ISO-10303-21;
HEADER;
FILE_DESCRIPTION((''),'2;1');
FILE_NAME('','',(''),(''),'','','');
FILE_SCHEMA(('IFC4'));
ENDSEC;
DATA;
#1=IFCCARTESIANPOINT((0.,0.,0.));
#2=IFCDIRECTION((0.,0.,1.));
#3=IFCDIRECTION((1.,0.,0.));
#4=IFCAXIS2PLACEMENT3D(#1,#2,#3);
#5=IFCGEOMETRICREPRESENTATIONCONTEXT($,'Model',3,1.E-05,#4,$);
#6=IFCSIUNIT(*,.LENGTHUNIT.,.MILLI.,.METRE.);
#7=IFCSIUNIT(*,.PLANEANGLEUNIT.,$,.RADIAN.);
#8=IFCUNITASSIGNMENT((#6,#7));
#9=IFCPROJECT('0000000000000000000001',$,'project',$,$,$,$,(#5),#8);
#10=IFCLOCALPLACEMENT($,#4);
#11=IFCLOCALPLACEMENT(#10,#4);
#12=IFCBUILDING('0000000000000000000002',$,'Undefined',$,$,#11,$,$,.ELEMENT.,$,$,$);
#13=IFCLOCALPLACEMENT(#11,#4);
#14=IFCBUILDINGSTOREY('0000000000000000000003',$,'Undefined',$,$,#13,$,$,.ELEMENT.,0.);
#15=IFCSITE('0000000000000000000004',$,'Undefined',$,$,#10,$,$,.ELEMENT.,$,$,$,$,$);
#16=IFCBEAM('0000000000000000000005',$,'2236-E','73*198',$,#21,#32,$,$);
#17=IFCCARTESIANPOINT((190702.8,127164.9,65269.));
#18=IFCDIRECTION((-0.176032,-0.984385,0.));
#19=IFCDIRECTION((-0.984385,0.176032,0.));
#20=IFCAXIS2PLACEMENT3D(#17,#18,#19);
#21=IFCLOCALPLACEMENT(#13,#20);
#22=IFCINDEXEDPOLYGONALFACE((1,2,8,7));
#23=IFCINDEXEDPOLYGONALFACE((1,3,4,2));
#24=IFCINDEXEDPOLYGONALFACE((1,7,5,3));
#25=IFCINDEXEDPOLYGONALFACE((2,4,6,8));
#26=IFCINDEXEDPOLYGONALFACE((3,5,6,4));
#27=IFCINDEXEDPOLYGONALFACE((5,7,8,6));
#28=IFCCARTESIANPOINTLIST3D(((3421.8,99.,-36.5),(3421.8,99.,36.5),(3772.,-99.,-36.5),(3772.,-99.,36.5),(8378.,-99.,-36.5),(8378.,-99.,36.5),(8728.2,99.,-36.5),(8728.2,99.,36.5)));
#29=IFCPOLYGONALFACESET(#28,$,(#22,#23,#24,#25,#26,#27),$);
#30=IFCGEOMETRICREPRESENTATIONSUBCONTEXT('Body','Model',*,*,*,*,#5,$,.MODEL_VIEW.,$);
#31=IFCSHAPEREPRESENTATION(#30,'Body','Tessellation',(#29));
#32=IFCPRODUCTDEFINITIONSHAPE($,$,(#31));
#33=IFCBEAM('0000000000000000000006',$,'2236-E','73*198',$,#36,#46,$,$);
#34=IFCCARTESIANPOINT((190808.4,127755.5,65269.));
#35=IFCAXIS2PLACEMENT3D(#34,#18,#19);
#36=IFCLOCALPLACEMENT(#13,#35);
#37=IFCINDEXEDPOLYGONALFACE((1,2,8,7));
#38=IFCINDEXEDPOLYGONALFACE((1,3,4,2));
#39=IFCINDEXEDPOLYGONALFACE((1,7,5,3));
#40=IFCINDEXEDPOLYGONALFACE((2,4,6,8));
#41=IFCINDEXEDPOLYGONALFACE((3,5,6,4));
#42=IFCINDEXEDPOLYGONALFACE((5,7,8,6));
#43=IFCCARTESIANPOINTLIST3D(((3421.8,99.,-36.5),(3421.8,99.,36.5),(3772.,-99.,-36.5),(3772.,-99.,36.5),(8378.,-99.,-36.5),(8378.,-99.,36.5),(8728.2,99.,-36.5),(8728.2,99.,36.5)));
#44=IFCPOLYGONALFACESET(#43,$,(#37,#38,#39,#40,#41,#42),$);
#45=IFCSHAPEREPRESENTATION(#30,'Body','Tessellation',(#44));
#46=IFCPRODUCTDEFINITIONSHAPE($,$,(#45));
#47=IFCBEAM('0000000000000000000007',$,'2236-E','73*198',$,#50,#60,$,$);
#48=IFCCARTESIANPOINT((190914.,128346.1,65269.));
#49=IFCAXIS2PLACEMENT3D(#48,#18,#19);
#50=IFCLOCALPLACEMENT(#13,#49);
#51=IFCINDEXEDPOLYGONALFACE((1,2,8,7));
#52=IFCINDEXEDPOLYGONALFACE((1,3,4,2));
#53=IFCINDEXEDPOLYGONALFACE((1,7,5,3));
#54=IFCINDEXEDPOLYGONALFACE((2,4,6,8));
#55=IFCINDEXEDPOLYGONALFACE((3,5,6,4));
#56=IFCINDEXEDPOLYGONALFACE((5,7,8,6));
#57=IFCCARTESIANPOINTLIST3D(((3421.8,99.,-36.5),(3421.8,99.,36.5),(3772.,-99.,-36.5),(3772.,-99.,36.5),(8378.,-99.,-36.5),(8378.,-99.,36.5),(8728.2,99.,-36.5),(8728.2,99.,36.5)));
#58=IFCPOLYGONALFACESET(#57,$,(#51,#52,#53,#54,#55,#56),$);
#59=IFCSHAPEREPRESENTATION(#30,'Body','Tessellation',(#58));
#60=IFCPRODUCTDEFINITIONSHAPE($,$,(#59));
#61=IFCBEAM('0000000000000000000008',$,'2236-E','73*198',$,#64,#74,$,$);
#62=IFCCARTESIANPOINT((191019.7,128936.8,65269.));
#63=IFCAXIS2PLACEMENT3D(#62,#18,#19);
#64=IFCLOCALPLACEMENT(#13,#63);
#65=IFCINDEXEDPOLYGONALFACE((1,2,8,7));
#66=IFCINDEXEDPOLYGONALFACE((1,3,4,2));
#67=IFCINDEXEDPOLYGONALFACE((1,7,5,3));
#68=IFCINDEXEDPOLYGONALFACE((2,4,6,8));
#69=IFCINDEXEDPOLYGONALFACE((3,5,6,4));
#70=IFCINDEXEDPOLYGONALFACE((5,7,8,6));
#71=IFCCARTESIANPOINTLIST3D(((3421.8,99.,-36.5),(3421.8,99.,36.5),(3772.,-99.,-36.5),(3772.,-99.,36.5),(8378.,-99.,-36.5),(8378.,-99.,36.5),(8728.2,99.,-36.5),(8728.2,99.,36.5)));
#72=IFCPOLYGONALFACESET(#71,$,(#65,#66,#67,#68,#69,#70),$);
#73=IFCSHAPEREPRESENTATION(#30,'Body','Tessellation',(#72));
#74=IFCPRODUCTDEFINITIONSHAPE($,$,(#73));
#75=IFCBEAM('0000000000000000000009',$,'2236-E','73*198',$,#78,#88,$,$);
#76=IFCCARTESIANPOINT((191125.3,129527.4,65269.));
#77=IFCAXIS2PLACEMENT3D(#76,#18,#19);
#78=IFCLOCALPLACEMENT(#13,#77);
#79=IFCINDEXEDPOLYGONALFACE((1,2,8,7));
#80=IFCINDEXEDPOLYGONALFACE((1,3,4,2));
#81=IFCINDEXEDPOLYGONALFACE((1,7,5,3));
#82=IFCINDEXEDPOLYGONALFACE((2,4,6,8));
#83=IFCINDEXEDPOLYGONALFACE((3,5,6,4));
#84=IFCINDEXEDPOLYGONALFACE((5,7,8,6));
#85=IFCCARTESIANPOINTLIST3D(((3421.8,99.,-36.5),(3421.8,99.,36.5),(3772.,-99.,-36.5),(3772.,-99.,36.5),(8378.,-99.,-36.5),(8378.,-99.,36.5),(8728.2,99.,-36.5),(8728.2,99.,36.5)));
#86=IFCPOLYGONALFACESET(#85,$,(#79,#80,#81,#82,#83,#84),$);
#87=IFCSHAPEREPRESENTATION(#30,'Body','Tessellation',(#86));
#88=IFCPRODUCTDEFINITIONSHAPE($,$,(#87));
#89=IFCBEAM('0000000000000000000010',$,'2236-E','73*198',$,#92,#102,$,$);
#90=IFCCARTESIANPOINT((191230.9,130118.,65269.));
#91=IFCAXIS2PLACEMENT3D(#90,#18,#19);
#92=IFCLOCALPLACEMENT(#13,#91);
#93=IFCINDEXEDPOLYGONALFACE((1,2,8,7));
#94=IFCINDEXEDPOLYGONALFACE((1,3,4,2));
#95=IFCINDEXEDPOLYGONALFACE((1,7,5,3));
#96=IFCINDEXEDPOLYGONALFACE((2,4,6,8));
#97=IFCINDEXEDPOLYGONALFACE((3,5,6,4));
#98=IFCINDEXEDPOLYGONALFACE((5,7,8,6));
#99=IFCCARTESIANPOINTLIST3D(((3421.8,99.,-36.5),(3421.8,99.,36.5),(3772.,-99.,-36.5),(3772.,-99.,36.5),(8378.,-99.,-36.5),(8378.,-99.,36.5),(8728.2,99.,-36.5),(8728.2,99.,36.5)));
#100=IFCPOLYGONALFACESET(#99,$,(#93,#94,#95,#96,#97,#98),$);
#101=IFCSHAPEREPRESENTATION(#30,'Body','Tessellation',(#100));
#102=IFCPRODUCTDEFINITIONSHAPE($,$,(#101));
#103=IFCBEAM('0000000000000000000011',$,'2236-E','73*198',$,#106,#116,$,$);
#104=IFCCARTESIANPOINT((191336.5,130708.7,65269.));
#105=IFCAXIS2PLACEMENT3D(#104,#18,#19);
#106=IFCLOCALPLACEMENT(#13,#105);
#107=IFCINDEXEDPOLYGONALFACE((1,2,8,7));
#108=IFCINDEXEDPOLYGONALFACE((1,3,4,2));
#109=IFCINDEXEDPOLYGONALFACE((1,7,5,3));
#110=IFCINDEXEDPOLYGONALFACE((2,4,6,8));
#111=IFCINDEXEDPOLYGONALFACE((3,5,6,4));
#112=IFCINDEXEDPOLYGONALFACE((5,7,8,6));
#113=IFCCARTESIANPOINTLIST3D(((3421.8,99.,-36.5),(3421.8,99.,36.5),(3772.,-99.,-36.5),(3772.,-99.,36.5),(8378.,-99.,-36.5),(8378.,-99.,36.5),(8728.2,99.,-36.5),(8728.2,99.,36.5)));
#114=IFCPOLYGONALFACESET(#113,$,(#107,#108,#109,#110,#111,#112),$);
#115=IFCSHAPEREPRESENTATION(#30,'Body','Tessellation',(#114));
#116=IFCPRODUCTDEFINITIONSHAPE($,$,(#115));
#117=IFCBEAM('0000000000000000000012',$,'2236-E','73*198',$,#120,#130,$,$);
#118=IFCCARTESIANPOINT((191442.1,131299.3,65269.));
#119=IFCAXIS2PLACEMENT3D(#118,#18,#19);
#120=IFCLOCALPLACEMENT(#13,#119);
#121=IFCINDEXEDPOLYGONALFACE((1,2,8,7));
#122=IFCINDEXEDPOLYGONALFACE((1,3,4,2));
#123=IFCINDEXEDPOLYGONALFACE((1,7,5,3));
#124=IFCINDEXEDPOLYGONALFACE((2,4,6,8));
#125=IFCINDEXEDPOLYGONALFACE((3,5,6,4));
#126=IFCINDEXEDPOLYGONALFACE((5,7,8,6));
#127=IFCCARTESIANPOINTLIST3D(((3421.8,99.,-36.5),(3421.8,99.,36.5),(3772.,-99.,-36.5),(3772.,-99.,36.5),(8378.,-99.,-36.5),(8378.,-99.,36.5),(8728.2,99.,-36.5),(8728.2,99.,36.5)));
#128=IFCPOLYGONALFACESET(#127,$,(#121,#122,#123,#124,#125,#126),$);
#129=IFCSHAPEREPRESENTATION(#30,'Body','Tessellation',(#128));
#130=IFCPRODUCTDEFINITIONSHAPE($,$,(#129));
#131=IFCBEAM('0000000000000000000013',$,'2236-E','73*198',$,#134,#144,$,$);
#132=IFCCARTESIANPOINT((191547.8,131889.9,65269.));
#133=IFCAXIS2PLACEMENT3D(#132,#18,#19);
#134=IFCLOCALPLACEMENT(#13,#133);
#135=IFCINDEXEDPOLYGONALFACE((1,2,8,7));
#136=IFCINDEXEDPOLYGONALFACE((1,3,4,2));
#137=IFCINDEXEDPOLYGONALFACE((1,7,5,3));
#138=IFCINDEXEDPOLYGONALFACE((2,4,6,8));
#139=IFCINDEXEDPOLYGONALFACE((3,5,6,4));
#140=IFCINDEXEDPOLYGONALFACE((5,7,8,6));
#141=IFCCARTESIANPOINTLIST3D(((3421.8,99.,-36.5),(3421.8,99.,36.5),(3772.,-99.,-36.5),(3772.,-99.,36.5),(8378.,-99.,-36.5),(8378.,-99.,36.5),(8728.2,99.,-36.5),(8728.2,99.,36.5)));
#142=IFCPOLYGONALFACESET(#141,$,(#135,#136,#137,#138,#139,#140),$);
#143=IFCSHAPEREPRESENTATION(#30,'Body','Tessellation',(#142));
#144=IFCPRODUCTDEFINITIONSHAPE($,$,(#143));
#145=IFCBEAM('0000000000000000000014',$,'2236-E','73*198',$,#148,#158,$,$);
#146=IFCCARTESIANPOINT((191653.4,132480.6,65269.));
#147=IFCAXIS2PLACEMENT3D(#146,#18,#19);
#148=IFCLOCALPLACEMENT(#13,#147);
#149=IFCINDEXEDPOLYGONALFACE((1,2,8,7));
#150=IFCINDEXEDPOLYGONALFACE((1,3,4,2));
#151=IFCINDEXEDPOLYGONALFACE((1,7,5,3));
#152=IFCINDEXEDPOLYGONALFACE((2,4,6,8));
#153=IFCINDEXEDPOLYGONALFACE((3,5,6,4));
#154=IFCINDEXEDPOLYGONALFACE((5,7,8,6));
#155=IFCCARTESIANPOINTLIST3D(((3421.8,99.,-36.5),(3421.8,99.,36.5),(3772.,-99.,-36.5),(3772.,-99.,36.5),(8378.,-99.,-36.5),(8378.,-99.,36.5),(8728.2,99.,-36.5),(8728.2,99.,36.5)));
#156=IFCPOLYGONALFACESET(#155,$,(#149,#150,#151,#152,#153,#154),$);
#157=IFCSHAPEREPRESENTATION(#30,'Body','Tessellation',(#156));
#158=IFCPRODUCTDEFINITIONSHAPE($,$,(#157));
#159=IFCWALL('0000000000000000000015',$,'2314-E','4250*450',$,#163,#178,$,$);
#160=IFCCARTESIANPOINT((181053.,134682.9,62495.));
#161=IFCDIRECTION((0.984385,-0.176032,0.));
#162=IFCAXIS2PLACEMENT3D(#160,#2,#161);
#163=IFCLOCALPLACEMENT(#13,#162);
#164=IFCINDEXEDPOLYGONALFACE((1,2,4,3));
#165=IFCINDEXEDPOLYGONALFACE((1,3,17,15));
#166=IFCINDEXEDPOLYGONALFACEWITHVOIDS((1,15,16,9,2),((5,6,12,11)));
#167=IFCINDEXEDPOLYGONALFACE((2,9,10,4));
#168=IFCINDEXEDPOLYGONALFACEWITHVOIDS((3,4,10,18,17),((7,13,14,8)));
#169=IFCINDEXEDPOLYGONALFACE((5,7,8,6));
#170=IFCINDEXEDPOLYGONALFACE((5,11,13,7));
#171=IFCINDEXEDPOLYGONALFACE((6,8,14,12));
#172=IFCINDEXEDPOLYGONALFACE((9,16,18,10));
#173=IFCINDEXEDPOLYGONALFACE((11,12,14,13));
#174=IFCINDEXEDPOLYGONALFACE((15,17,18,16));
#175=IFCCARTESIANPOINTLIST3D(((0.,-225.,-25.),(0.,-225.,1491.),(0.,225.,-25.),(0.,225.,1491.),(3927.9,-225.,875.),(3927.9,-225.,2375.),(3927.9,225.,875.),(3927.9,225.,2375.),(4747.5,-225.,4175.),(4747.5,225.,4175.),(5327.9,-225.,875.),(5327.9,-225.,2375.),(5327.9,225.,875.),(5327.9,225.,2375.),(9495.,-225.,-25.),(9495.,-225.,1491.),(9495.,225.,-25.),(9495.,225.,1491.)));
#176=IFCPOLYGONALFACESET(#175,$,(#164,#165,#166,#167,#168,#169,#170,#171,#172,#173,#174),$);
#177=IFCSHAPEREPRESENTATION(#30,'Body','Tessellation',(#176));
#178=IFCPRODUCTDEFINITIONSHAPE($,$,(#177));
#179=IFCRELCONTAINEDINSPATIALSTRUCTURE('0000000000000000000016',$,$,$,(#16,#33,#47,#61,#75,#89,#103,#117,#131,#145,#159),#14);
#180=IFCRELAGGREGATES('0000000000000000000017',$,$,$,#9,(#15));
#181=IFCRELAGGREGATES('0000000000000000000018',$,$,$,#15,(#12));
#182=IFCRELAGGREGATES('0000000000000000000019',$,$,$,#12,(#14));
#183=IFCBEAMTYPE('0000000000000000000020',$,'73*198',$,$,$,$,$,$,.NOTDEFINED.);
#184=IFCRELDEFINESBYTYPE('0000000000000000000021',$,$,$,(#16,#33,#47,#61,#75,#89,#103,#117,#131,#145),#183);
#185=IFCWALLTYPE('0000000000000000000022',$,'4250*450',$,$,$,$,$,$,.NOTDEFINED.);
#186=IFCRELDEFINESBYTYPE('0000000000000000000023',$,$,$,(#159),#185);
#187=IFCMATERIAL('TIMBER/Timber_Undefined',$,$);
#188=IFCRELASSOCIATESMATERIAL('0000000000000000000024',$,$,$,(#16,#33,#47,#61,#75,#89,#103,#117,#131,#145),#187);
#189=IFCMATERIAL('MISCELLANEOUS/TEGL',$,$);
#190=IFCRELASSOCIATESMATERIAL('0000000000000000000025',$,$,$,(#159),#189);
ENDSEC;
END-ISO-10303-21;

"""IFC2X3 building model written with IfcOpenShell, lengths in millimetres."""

from ifc_helpers import new_model, si_unit, frame, frame_2d, origin_with_axes, origin_2d_with_axis, place, context, subcontext, project, spatial, rectangle, extrude, boolean, clip, halfspace, material, type_object, element, save


model = new_model("IFC2X3")

# Units and contexts
model_context = context("Model", 3, precision=1e-05, world=origin_with_axes())
body_context = subcontext(model_context, "Body", "Model", "MODEL_VIEW")
ifc_project = project(units=[si_unit("LENGTHUNIT", "METRE", prefix="MILLI"), si_unit("PLANEANGLEUNIT", "RADIAN")], contexts=[model_context])

# Site, building, storey
site_placement = place(None, origin_with_axes())
site = spatial("IfcSite", under=ifc_project, at=site_placement, Name="Undefined", CompositionType="ELEMENT")
building_placement = place(site_placement, origin_with_axes())
building = spatial("IfcBuilding", under=site, at=building_placement, Name="Undefined", CompositionType="ELEMENT")
storey_placement = place(building_placement, origin_with_axes())
storey = spatial("IfcBuildingStorey", under=building, at=storey_placement, Name="Undefined", CompositionType="ELEMENT", Elevation=0.0)

# Shared definitions
ifc_material_1 = material(Name="TIMBER/Timber_Undefined")

# Beams
beam_type = type_object("IfcBeamType", Name="73*198", PredefinedType="NOTDEFINED")
for number, where, z_axis, x_axis, name in (
    (1, (190702.8, 127164.9, 65269.0), (-0.176032, -0.984385, 0.0), (-0.984385, 0.176032, 0.0), "2236-E"),
    (2, (190808.4, 127755.5, 65269.0), (-0.176032, -0.984385, 0.0), (-0.984385, 0.176032, 0.0), "2236-E"),
    (3, (190914.0, 128346.1, 65269.0), (-0.176032, -0.984385, 0.0), (-0.984385, 0.176032, 0.0), "2236-E"),
    (4, (191019.7, 128936.8, 65269.0), (-0.176032, -0.984385, 0.0), (-0.984385, 0.176032, 0.0), "2236-E"),
    (5, (191125.3, 129527.4, 65269.0), (-0.176032, -0.984385, 0.0), (-0.984385, 0.176032, 0.0), "2236-E"),
    (6, (191230.9, 130118.0, 65269.0), (-0.176032, -0.984385, 0.0), (-0.984385, 0.176032, 0.0), "2236-E"),
    (7, (191336.5, 130708.7, 65269.0), (-0.176032, -0.984385, 0.0), (-0.984385, 0.176032, 0.0), "2236-E"),
    (8, (191442.1, 131299.3, 65269.0), (-0.176032, -0.984385, 0.0), (-0.984385, 0.176032, 0.0), "2236-E"),
    (9, (191547.8, 131889.9, 65269.0), (-0.176032, -0.984385, 0.0), (-0.984385, 0.176032, 0.0), "2236-E"),
    (10, (191653.4, 132480.6, 65269.0), (-0.176032, -0.984385, 0.0), (-0.984385, 0.176032, 0.0), "2236-E"),
):
    element("IfcBeam", number, at=place(storey_placement, frame(where, z_axis=z_axis, x_axis=x_axis)), inside=storey, type_object=beam_type, material=ifc_material_1, Name=name, Description="73*198", context=body_context, shape_type="Clipping", body=[
        clip(clip(extrude(rectangle(XDim=198.0, YDim=73.0, at=origin_2d_with_axis()), frame((14325.0, 0.0, 0.0), z_axis=(-1.0, 0.0, 0.0), x_axis=(0.0, -1.0, 0.0)), (0.0, 0.0, 1.0), 14325.0), halfspace(frame((3772.0, -99.0, 36.5), z_axis=(-0.492144, -0.870514, 0.0), x_axis=(0.0, 0.0, -1.0)), False)), halfspace(frame((8728.2, 99.0, 36.5), z_axis=(0.492144, -0.870514, 0.0), x_axis=(0.0, 0.0, -1.0)), False)),
    ])

# Wall
ifc_material_2 = material(Name="MISCELLANEOUS/TEGL")
wall_type_1 = type_object("IfcWallType", Name="4250*450", PredefinedType="NOTDEFINED")
wall_1_placement = place(storey_placement, frame((181053.0, 134682.9, 62495.0), z_axis=(0.0, 0.0, 1.0), x_axis=(0.984385, -0.176032, 0.0)))
element("IfcWall", 11, at=wall_1_placement, inside=storey, type_object=wall_type_1, material=ifc_material_2, Name="2314-E", Description="4250*450", context=body_context, shape_type="CSG", body=[
    boolean("DIFFERENCE", boolean("DIFFERENCE", boolean("DIFFERENCE", extrude(rectangle(XDim=9495.0, YDim=450.0, at=frame_2d((0.0, 4747.5), x_axis=(0.0, -1.0))), frame((0.0, 0.0, -25.0), z_axis=(0.0, 0.0, 1.0), x_axis=(0.0, -1.0, 0.0)), (0.0, 0.0, 1.0), 4250.0), extrude(rectangle(XDim=1400.0, YDim=450.0, at=frame_2d((0.0, 700.0), x_axis=(0.0, -1.0))), frame((3927.9, 0.0, 875.0), z_axis=(0.0, 0.0, 1.0), x_axis=(0.0, -1.0, 0.0)), (0.0, 0.0, 1.0), 1500.0)), halfspace(frame((5012.8, 225.0, 4025.0), z_axis=(0.492144, 0.0, 0.870514), x_axis=(0.870514, 0.0, -0.492144)), False)), halfspace(frame((-2681.5, 225.0, -25.0), z_axis=(-0.492144, 0.0, 0.870514), x_axis=(0.870514, 0.0, 0.492144)), False)),
])

save(model, "model.ifc")
